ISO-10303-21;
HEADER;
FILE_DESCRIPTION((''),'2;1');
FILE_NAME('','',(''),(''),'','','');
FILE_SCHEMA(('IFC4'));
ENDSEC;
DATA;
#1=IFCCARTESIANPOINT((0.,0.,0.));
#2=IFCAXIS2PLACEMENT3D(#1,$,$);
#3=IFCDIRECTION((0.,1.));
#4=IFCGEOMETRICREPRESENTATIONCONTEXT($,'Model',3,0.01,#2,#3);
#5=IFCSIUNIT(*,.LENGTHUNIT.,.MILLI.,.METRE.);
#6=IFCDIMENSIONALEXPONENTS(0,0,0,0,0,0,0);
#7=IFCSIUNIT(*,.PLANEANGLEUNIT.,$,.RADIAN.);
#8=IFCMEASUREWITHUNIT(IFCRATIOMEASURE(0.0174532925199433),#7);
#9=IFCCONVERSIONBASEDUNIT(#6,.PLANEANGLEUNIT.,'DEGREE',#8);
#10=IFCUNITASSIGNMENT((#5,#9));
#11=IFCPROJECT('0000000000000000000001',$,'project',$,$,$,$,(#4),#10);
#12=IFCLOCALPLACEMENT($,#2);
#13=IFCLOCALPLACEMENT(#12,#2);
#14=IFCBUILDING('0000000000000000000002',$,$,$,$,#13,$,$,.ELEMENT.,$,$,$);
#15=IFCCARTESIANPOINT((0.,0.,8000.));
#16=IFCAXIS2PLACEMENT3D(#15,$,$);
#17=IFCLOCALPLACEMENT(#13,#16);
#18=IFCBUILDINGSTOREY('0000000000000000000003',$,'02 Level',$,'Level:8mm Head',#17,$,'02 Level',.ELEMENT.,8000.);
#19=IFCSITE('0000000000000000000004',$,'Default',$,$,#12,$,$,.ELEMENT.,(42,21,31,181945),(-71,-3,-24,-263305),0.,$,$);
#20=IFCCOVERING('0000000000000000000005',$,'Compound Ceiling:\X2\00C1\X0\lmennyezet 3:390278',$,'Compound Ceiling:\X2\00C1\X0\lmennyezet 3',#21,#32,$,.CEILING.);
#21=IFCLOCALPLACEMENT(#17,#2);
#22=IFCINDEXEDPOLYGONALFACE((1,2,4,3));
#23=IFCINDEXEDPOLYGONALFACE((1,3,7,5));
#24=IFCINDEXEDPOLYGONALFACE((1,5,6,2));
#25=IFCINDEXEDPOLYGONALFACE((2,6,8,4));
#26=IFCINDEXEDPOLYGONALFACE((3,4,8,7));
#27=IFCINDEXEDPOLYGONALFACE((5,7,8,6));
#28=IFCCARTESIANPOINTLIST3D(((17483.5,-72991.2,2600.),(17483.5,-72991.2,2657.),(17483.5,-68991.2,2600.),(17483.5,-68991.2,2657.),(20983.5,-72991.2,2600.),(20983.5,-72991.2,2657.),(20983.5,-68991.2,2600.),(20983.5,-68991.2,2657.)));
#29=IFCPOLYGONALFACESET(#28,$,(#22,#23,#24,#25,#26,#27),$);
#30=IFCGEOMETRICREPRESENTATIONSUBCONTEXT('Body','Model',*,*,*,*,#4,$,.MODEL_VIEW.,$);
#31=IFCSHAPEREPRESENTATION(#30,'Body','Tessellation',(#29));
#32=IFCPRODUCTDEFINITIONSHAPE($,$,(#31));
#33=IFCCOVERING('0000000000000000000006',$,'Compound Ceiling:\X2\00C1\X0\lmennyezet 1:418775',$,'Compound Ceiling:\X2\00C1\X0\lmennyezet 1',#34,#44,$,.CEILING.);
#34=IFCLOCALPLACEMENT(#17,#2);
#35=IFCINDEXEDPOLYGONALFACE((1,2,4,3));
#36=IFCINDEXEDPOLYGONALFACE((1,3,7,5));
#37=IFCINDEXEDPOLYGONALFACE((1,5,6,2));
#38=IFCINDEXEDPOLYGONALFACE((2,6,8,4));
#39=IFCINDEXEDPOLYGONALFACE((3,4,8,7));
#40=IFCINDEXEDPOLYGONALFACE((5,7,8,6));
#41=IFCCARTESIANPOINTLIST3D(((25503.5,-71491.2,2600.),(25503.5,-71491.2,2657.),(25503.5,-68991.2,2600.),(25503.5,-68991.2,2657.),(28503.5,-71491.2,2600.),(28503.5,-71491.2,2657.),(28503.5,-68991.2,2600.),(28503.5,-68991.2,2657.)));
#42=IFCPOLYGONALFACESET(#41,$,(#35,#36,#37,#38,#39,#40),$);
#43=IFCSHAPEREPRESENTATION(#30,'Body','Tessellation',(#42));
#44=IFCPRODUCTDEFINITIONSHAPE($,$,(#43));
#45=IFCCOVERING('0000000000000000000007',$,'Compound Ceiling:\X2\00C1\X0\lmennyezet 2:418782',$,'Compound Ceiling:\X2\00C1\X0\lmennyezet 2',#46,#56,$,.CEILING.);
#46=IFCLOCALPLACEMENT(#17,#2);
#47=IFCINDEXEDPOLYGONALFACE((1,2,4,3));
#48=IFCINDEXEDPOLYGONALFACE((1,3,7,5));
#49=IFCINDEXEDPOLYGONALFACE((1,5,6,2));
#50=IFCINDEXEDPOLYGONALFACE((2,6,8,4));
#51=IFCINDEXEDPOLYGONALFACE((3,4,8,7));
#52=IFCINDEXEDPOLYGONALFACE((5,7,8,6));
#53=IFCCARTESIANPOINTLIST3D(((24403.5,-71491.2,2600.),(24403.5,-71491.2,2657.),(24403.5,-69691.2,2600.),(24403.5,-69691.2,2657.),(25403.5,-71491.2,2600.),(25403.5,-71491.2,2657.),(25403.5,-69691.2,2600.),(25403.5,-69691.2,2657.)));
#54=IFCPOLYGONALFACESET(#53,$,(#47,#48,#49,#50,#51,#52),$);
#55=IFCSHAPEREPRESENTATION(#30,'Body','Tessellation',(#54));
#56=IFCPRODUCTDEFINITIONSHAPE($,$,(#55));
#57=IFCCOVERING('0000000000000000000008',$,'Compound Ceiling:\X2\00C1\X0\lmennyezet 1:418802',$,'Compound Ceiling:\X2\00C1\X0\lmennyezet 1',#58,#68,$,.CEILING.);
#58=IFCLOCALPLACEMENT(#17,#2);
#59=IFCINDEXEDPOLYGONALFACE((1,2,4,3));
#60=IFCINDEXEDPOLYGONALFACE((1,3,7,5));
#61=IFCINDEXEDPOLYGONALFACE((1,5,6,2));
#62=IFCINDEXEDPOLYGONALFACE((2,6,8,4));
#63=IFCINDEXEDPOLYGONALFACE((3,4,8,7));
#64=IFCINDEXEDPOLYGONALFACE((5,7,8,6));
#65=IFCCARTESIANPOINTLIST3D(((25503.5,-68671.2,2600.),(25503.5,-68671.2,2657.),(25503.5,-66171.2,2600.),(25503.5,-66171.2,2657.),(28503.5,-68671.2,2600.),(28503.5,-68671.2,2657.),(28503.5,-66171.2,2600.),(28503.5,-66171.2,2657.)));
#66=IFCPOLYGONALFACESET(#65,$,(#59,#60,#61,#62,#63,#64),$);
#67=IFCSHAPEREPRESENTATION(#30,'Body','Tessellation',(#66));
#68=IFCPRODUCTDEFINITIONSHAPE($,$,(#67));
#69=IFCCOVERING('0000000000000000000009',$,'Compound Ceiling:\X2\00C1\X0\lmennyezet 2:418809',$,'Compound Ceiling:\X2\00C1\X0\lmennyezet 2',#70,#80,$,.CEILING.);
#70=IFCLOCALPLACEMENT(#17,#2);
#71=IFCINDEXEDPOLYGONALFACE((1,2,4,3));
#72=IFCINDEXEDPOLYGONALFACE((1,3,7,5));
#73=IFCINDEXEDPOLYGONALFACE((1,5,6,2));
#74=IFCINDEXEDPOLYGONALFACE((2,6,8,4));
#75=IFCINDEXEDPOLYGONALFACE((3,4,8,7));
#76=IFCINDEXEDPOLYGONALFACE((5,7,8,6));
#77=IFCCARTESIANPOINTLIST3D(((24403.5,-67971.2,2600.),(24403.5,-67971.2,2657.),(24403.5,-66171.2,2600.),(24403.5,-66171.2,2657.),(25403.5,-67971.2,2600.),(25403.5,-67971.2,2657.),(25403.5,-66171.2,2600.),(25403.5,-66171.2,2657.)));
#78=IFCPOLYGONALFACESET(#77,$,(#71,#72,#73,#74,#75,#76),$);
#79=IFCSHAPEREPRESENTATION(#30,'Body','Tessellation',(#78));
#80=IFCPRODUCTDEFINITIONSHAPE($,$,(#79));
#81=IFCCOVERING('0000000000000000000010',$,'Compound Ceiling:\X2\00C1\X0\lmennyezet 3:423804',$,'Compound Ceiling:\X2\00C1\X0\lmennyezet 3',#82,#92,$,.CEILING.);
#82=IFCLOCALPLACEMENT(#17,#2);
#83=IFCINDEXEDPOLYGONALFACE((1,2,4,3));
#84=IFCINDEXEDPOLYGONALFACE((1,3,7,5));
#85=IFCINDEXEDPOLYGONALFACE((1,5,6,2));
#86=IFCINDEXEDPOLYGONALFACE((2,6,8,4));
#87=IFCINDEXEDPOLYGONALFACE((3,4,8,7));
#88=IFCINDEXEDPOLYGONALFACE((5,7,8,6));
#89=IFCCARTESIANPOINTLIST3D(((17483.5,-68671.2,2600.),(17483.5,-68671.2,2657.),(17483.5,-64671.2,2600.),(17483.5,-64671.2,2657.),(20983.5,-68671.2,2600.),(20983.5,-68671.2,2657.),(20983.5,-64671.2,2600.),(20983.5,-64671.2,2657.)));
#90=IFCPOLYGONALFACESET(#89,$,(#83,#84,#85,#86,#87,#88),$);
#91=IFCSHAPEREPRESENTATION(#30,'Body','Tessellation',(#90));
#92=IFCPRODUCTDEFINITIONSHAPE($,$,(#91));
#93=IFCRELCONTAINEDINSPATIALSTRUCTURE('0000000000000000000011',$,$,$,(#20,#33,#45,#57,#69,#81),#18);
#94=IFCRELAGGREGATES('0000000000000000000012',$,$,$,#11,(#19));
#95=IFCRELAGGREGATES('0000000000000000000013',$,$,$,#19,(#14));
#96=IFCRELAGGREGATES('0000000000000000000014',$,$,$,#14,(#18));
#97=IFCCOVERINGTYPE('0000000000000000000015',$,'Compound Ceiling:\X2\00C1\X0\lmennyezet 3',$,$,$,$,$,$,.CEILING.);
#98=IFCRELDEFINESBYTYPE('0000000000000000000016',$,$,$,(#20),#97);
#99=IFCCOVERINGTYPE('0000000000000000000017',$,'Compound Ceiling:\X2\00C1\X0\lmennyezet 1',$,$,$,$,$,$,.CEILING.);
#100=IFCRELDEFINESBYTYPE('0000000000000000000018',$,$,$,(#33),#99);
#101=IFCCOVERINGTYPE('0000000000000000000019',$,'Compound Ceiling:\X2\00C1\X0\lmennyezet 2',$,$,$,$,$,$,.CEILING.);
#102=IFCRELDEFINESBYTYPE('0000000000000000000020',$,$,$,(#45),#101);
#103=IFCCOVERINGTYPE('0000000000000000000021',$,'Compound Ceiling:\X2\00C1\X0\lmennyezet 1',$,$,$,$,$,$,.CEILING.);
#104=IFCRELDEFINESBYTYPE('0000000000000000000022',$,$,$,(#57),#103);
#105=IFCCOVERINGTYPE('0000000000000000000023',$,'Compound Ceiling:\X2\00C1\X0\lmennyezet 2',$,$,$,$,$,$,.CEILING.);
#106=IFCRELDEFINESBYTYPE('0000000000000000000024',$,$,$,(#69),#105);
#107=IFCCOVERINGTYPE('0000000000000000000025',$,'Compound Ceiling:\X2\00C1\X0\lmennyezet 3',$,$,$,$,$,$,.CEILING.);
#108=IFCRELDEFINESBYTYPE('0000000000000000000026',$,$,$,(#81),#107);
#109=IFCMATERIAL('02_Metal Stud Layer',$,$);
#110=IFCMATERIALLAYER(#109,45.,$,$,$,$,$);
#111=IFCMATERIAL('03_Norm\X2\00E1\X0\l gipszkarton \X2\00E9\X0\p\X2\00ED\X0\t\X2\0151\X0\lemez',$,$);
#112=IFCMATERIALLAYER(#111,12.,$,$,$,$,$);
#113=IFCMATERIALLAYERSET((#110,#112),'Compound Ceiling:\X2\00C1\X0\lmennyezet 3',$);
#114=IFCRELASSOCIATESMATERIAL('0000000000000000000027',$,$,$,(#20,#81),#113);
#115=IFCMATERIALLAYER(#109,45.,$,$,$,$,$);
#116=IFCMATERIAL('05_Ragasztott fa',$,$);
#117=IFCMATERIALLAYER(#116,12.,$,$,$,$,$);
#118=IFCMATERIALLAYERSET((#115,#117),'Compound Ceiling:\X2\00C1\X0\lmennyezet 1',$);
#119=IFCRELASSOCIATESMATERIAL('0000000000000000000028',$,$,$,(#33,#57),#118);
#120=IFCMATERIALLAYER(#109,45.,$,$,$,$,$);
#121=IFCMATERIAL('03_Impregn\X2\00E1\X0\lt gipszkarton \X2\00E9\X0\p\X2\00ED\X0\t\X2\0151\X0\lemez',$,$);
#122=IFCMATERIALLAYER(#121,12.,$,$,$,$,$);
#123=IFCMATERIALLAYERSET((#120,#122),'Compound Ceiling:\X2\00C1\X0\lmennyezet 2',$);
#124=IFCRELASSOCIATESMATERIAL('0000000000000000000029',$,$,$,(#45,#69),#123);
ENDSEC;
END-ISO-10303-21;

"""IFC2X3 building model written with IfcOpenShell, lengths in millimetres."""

from ifc_helpers import new_model, entity, si_unit, converted_unit, direction, frame, frame_2d, origin, origin_2d_with_axis, place, context, subcontext, project, spatial, rectangle, extrude, material, layer, layer_set, layer_usage, type_object, element, save


model = new_model("IFC2X3")

# Units and contexts
model_context = context("Model", 3, precision=0.01, world=origin(), true_north=direction((0.0, 1.0)))
body_context = subcontext(model_context, "Body", "Model", "MODEL_VIEW")
ifc_project = project(units=[si_unit("LENGTHUNIT", "METRE", prefix="MILLI"), converted_unit("PLANEANGLEUNIT", "DEGREE", entity("IfcRatioMeasure", 0.0174532925199433), si_unit("PLANEANGLEUNIT", "RADIAN"), dimensions=[0, 0, 0, 0, 0, 0, 0])], contexts=[model_context])

# Site, building, storey
site_placement = place(None, origin())
site = spatial("IfcSite", under=ifc_project, at=site_placement, Name="Default", CompositionType="ELEMENT", RefLatitude=(42, 21, 31, 181945), RefLongitude=(-71, -3, -24, -263305), RefElevation=0.0)
building_placement = place(site_placement, origin())
building = spatial("IfcBuilding", under=site, at=building_placement, CompositionType="ELEMENT")
storey_placement = place(building_placement, frame((0.0, 0.0, 8000.0)))
storey = spatial("IfcBuildingStorey", under=building, at=storey_placement, Name="02 Level", ObjectType="Level:8mm Head", LongName="02 Level", CompositionType="ELEMENT", Elevation=8000.0)

# Coverings
ifc_material_1 = material(Name="02_Metal Stud Layer")
ifc_layer_1 = layer(ifc_material_1, 45.0)
ifc_material_2 = material(Name="03_Normál gipszkarton építőlemez")
ifc_layer_2 = layer(ifc_material_2, 12.0)
ifc_layer_set_1 = layer_set([ifc_layer_1, ifc_layer_2], Name="Compound Ceiling:Álmennyezet 3")
ifc_layer_usage_1 = layer_usage(ifc_layer_set_1, "AXIS3", "POSITIVE", 0.0)
covering_type_1 = type_object("IfcCoveringType", Name="Compound Ceiling:Álmennyezet 3", PredefinedType="CEILING")
covering_1_placement = place(storey_placement, frame((17483.5, -72991.2, 2600.0)))
element("IfcCovering", 1, at=covering_1_placement, inside=storey, type_object=covering_type_1, material=ifc_layer_usage_1, Name="Compound Ceiling:Álmennyezet 3:390278", ObjectType="Compound Ceiling:Álmennyezet 3", PredefinedType="CEILING", context=body_context, shape_type="SweptSolid", body=[
    extrude(rectangle(XDim=4000.0, YDim=3500.0, at=frame_2d((0.0, 0.0), x_axis=(1.0, 0.0))), frame((1750.0, 2000.0, 0.0), z_axis=(0.0, 0.0, 1.0), x_axis=(0.0, 1.0, 0.0)), (0.0, 0.0, 1.0), 57.0),
])
ifc_layer_3 = layer(ifc_material_1, 45.0)
ifc_material_3 = material(Name="05_Ragasztott fa")
ifc_layer_4 = layer(ifc_material_3, 12.0)
ifc_layer_set_2 = layer_set([ifc_layer_3, ifc_layer_4], Name="Compound Ceiling:Álmennyezet 1")
ifc_layer_usage_2 = layer_usage(ifc_layer_set_2, "AXIS3", "POSITIVE", 0.0)
covering_type_2 = type_object("IfcCoveringType", Name="Compound Ceiling:Álmennyezet 1", PredefinedType="CEILING")
covering_2_placement = place(storey_placement, frame((25503.5, -71491.2, 2600.0)))
element("IfcCovering", 2, at=covering_2_placement, inside=storey, type_object=covering_type_2, material=ifc_layer_usage_2, Name="Compound Ceiling:Álmennyezet 1:418775", ObjectType="Compound Ceiling:Álmennyezet 1", PredefinedType="CEILING", context=body_context, shape_type="SweptSolid", body=[
    extrude(rectangle(XDim=3000.0, YDim=2500.0, at=frame_2d((0.0, 0.0), x_axis=(1.0, 0.0))), frame((1500.0, 1250.0, 0.0), z_axis=(0.0, 0.0, 1.0), x_axis=(-1.0, 0.0, 0.0)), (0.0, 0.0, 1.0), 57.0),
])
ifc_layer_5 = layer(ifc_material_1, 45.0)
ifc_material_4 = material(Name="03_Impregnált gipszkarton építőlemez")
ifc_layer_6 = layer(ifc_material_4, 12.0)
ifc_layer_set_3 = layer_set([ifc_layer_5, ifc_layer_6], Name="Compound Ceiling:Álmennyezet 2")
ifc_layer_usage_3 = layer_usage(ifc_layer_set_3, "AXIS3", "POSITIVE", 0.0)
covering_type_3 = type_object("IfcCoveringType", Name="Compound Ceiling:Álmennyezet 2", PredefinedType="CEILING")
covering_3_placement = place(storey_placement, frame((24403.5, -71491.2, 2600.0)))
element("IfcCovering", 3, at=covering_3_placement, inside=storey, type_object=covering_type_3, material=ifc_layer_usage_3, Name="Compound Ceiling:Álmennyezet 2:418782", ObjectType="Compound Ceiling:Álmennyezet 2", PredefinedType="CEILING", context=body_context, shape_type="SweptSolid", body=[
    extrude(rectangle(XDim=1000.0, YDim=1800.0, at=frame_2d((0.0, 0.0), x_axis=(1.0, 0.0))), frame((500.0, 900.0, 0.0), z_axis=(0.0, 0.0, 1.0), x_axis=(-1.0, 0.0, 0.0)), (0.0, 0.0, 1.0), 57.0),
])
ifc_layer_usage_4 = layer_usage(ifc_layer_set_2, "AXIS3", "POSITIVE", 0.0)
covering_type_4 = type_object("IfcCoveringType", Name="Compound Ceiling:Álmennyezet 1", PredefinedType="CEILING")
covering_4_placement = place(storey_placement, frame((25503.5, -68671.2, 2600.0)))
element("IfcCovering", 4, at=covering_4_placement, inside=storey, type_object=covering_type_4, material=ifc_layer_usage_4, Name="Compound Ceiling:Álmennyezet 1:418802", ObjectType="Compound Ceiling:Álmennyezet 1", PredefinedType="CEILING", context=body_context, shape_type="SweptSolid", body=[
    extrude(rectangle(XDim=2500.0, YDim=3000.0, at=frame_2d((0.0, 0.0), x_axis=(1.0, 0.0))), frame((1500.0, 1250.0, 0.0), z_axis=(0.0, 0.0, 1.0), x_axis=(0.0, 1.0, 0.0)), (0.0, 0.0, 1.0), 57.0),
])
ifc_layer_usage_5 = layer_usage(ifc_layer_set_3, "AXIS3", "POSITIVE", 0.0)
covering_type_5 = type_object("IfcCoveringType", Name="Compound Ceiling:Álmennyezet 2", PredefinedType="CEILING")
covering_5_placement = place(storey_placement, frame((24403.5, -67971.2, 2600.0)))
element("IfcCovering", 5, at=covering_5_placement, inside=storey, type_object=covering_type_5, material=ifc_layer_usage_5, Name="Compound Ceiling:Álmennyezet 2:418809", ObjectType="Compound Ceiling:Álmennyezet 2", PredefinedType="CEILING", context=body_context, shape_type="SweptSolid", body=[
    extrude(rectangle(XDim=1800.0, YDim=1000.0, at=origin_2d_with_axis()), frame((500.0, 900.0, 0.0), z_axis=(0.0, 0.0, 1.0), x_axis=(0.0, 1.0, 0.0)), (0.0, 0.0, 1.0), 57.0),
])
ifc_layer_usage_6 = layer_usage(ifc_layer_set_1, "AXIS3", "POSITIVE", 0.0)
covering_type_6 = type_object("IfcCoveringType", Name="Compound Ceiling:Álmennyezet 3", PredefinedType="CEILING")
covering_6_placement = place(storey_placement, frame((17483.5, -68671.2, 2600.0)))
element("IfcCovering", 6, at=covering_6_placement, inside=storey, type_object=covering_type_6, material=ifc_layer_usage_6, Name="Compound Ceiling:Álmennyezet 3:423804", ObjectType="Compound Ceiling:Álmennyezet 3", PredefinedType="CEILING", context=body_context, shape_type="SweptSolid", body=[
    extrude(rectangle(XDim=3500.0, YDim=4000.0, at=origin_2d_with_axis()), frame((1750.0, 2000.0, 0.0), z_axis=(0.0, 0.0, 1.0), x_axis=(-1.0, 0.0, 0.0)), (0.0, 0.0, 1.0), 57.0),
])

save(model, "model.ifc")
